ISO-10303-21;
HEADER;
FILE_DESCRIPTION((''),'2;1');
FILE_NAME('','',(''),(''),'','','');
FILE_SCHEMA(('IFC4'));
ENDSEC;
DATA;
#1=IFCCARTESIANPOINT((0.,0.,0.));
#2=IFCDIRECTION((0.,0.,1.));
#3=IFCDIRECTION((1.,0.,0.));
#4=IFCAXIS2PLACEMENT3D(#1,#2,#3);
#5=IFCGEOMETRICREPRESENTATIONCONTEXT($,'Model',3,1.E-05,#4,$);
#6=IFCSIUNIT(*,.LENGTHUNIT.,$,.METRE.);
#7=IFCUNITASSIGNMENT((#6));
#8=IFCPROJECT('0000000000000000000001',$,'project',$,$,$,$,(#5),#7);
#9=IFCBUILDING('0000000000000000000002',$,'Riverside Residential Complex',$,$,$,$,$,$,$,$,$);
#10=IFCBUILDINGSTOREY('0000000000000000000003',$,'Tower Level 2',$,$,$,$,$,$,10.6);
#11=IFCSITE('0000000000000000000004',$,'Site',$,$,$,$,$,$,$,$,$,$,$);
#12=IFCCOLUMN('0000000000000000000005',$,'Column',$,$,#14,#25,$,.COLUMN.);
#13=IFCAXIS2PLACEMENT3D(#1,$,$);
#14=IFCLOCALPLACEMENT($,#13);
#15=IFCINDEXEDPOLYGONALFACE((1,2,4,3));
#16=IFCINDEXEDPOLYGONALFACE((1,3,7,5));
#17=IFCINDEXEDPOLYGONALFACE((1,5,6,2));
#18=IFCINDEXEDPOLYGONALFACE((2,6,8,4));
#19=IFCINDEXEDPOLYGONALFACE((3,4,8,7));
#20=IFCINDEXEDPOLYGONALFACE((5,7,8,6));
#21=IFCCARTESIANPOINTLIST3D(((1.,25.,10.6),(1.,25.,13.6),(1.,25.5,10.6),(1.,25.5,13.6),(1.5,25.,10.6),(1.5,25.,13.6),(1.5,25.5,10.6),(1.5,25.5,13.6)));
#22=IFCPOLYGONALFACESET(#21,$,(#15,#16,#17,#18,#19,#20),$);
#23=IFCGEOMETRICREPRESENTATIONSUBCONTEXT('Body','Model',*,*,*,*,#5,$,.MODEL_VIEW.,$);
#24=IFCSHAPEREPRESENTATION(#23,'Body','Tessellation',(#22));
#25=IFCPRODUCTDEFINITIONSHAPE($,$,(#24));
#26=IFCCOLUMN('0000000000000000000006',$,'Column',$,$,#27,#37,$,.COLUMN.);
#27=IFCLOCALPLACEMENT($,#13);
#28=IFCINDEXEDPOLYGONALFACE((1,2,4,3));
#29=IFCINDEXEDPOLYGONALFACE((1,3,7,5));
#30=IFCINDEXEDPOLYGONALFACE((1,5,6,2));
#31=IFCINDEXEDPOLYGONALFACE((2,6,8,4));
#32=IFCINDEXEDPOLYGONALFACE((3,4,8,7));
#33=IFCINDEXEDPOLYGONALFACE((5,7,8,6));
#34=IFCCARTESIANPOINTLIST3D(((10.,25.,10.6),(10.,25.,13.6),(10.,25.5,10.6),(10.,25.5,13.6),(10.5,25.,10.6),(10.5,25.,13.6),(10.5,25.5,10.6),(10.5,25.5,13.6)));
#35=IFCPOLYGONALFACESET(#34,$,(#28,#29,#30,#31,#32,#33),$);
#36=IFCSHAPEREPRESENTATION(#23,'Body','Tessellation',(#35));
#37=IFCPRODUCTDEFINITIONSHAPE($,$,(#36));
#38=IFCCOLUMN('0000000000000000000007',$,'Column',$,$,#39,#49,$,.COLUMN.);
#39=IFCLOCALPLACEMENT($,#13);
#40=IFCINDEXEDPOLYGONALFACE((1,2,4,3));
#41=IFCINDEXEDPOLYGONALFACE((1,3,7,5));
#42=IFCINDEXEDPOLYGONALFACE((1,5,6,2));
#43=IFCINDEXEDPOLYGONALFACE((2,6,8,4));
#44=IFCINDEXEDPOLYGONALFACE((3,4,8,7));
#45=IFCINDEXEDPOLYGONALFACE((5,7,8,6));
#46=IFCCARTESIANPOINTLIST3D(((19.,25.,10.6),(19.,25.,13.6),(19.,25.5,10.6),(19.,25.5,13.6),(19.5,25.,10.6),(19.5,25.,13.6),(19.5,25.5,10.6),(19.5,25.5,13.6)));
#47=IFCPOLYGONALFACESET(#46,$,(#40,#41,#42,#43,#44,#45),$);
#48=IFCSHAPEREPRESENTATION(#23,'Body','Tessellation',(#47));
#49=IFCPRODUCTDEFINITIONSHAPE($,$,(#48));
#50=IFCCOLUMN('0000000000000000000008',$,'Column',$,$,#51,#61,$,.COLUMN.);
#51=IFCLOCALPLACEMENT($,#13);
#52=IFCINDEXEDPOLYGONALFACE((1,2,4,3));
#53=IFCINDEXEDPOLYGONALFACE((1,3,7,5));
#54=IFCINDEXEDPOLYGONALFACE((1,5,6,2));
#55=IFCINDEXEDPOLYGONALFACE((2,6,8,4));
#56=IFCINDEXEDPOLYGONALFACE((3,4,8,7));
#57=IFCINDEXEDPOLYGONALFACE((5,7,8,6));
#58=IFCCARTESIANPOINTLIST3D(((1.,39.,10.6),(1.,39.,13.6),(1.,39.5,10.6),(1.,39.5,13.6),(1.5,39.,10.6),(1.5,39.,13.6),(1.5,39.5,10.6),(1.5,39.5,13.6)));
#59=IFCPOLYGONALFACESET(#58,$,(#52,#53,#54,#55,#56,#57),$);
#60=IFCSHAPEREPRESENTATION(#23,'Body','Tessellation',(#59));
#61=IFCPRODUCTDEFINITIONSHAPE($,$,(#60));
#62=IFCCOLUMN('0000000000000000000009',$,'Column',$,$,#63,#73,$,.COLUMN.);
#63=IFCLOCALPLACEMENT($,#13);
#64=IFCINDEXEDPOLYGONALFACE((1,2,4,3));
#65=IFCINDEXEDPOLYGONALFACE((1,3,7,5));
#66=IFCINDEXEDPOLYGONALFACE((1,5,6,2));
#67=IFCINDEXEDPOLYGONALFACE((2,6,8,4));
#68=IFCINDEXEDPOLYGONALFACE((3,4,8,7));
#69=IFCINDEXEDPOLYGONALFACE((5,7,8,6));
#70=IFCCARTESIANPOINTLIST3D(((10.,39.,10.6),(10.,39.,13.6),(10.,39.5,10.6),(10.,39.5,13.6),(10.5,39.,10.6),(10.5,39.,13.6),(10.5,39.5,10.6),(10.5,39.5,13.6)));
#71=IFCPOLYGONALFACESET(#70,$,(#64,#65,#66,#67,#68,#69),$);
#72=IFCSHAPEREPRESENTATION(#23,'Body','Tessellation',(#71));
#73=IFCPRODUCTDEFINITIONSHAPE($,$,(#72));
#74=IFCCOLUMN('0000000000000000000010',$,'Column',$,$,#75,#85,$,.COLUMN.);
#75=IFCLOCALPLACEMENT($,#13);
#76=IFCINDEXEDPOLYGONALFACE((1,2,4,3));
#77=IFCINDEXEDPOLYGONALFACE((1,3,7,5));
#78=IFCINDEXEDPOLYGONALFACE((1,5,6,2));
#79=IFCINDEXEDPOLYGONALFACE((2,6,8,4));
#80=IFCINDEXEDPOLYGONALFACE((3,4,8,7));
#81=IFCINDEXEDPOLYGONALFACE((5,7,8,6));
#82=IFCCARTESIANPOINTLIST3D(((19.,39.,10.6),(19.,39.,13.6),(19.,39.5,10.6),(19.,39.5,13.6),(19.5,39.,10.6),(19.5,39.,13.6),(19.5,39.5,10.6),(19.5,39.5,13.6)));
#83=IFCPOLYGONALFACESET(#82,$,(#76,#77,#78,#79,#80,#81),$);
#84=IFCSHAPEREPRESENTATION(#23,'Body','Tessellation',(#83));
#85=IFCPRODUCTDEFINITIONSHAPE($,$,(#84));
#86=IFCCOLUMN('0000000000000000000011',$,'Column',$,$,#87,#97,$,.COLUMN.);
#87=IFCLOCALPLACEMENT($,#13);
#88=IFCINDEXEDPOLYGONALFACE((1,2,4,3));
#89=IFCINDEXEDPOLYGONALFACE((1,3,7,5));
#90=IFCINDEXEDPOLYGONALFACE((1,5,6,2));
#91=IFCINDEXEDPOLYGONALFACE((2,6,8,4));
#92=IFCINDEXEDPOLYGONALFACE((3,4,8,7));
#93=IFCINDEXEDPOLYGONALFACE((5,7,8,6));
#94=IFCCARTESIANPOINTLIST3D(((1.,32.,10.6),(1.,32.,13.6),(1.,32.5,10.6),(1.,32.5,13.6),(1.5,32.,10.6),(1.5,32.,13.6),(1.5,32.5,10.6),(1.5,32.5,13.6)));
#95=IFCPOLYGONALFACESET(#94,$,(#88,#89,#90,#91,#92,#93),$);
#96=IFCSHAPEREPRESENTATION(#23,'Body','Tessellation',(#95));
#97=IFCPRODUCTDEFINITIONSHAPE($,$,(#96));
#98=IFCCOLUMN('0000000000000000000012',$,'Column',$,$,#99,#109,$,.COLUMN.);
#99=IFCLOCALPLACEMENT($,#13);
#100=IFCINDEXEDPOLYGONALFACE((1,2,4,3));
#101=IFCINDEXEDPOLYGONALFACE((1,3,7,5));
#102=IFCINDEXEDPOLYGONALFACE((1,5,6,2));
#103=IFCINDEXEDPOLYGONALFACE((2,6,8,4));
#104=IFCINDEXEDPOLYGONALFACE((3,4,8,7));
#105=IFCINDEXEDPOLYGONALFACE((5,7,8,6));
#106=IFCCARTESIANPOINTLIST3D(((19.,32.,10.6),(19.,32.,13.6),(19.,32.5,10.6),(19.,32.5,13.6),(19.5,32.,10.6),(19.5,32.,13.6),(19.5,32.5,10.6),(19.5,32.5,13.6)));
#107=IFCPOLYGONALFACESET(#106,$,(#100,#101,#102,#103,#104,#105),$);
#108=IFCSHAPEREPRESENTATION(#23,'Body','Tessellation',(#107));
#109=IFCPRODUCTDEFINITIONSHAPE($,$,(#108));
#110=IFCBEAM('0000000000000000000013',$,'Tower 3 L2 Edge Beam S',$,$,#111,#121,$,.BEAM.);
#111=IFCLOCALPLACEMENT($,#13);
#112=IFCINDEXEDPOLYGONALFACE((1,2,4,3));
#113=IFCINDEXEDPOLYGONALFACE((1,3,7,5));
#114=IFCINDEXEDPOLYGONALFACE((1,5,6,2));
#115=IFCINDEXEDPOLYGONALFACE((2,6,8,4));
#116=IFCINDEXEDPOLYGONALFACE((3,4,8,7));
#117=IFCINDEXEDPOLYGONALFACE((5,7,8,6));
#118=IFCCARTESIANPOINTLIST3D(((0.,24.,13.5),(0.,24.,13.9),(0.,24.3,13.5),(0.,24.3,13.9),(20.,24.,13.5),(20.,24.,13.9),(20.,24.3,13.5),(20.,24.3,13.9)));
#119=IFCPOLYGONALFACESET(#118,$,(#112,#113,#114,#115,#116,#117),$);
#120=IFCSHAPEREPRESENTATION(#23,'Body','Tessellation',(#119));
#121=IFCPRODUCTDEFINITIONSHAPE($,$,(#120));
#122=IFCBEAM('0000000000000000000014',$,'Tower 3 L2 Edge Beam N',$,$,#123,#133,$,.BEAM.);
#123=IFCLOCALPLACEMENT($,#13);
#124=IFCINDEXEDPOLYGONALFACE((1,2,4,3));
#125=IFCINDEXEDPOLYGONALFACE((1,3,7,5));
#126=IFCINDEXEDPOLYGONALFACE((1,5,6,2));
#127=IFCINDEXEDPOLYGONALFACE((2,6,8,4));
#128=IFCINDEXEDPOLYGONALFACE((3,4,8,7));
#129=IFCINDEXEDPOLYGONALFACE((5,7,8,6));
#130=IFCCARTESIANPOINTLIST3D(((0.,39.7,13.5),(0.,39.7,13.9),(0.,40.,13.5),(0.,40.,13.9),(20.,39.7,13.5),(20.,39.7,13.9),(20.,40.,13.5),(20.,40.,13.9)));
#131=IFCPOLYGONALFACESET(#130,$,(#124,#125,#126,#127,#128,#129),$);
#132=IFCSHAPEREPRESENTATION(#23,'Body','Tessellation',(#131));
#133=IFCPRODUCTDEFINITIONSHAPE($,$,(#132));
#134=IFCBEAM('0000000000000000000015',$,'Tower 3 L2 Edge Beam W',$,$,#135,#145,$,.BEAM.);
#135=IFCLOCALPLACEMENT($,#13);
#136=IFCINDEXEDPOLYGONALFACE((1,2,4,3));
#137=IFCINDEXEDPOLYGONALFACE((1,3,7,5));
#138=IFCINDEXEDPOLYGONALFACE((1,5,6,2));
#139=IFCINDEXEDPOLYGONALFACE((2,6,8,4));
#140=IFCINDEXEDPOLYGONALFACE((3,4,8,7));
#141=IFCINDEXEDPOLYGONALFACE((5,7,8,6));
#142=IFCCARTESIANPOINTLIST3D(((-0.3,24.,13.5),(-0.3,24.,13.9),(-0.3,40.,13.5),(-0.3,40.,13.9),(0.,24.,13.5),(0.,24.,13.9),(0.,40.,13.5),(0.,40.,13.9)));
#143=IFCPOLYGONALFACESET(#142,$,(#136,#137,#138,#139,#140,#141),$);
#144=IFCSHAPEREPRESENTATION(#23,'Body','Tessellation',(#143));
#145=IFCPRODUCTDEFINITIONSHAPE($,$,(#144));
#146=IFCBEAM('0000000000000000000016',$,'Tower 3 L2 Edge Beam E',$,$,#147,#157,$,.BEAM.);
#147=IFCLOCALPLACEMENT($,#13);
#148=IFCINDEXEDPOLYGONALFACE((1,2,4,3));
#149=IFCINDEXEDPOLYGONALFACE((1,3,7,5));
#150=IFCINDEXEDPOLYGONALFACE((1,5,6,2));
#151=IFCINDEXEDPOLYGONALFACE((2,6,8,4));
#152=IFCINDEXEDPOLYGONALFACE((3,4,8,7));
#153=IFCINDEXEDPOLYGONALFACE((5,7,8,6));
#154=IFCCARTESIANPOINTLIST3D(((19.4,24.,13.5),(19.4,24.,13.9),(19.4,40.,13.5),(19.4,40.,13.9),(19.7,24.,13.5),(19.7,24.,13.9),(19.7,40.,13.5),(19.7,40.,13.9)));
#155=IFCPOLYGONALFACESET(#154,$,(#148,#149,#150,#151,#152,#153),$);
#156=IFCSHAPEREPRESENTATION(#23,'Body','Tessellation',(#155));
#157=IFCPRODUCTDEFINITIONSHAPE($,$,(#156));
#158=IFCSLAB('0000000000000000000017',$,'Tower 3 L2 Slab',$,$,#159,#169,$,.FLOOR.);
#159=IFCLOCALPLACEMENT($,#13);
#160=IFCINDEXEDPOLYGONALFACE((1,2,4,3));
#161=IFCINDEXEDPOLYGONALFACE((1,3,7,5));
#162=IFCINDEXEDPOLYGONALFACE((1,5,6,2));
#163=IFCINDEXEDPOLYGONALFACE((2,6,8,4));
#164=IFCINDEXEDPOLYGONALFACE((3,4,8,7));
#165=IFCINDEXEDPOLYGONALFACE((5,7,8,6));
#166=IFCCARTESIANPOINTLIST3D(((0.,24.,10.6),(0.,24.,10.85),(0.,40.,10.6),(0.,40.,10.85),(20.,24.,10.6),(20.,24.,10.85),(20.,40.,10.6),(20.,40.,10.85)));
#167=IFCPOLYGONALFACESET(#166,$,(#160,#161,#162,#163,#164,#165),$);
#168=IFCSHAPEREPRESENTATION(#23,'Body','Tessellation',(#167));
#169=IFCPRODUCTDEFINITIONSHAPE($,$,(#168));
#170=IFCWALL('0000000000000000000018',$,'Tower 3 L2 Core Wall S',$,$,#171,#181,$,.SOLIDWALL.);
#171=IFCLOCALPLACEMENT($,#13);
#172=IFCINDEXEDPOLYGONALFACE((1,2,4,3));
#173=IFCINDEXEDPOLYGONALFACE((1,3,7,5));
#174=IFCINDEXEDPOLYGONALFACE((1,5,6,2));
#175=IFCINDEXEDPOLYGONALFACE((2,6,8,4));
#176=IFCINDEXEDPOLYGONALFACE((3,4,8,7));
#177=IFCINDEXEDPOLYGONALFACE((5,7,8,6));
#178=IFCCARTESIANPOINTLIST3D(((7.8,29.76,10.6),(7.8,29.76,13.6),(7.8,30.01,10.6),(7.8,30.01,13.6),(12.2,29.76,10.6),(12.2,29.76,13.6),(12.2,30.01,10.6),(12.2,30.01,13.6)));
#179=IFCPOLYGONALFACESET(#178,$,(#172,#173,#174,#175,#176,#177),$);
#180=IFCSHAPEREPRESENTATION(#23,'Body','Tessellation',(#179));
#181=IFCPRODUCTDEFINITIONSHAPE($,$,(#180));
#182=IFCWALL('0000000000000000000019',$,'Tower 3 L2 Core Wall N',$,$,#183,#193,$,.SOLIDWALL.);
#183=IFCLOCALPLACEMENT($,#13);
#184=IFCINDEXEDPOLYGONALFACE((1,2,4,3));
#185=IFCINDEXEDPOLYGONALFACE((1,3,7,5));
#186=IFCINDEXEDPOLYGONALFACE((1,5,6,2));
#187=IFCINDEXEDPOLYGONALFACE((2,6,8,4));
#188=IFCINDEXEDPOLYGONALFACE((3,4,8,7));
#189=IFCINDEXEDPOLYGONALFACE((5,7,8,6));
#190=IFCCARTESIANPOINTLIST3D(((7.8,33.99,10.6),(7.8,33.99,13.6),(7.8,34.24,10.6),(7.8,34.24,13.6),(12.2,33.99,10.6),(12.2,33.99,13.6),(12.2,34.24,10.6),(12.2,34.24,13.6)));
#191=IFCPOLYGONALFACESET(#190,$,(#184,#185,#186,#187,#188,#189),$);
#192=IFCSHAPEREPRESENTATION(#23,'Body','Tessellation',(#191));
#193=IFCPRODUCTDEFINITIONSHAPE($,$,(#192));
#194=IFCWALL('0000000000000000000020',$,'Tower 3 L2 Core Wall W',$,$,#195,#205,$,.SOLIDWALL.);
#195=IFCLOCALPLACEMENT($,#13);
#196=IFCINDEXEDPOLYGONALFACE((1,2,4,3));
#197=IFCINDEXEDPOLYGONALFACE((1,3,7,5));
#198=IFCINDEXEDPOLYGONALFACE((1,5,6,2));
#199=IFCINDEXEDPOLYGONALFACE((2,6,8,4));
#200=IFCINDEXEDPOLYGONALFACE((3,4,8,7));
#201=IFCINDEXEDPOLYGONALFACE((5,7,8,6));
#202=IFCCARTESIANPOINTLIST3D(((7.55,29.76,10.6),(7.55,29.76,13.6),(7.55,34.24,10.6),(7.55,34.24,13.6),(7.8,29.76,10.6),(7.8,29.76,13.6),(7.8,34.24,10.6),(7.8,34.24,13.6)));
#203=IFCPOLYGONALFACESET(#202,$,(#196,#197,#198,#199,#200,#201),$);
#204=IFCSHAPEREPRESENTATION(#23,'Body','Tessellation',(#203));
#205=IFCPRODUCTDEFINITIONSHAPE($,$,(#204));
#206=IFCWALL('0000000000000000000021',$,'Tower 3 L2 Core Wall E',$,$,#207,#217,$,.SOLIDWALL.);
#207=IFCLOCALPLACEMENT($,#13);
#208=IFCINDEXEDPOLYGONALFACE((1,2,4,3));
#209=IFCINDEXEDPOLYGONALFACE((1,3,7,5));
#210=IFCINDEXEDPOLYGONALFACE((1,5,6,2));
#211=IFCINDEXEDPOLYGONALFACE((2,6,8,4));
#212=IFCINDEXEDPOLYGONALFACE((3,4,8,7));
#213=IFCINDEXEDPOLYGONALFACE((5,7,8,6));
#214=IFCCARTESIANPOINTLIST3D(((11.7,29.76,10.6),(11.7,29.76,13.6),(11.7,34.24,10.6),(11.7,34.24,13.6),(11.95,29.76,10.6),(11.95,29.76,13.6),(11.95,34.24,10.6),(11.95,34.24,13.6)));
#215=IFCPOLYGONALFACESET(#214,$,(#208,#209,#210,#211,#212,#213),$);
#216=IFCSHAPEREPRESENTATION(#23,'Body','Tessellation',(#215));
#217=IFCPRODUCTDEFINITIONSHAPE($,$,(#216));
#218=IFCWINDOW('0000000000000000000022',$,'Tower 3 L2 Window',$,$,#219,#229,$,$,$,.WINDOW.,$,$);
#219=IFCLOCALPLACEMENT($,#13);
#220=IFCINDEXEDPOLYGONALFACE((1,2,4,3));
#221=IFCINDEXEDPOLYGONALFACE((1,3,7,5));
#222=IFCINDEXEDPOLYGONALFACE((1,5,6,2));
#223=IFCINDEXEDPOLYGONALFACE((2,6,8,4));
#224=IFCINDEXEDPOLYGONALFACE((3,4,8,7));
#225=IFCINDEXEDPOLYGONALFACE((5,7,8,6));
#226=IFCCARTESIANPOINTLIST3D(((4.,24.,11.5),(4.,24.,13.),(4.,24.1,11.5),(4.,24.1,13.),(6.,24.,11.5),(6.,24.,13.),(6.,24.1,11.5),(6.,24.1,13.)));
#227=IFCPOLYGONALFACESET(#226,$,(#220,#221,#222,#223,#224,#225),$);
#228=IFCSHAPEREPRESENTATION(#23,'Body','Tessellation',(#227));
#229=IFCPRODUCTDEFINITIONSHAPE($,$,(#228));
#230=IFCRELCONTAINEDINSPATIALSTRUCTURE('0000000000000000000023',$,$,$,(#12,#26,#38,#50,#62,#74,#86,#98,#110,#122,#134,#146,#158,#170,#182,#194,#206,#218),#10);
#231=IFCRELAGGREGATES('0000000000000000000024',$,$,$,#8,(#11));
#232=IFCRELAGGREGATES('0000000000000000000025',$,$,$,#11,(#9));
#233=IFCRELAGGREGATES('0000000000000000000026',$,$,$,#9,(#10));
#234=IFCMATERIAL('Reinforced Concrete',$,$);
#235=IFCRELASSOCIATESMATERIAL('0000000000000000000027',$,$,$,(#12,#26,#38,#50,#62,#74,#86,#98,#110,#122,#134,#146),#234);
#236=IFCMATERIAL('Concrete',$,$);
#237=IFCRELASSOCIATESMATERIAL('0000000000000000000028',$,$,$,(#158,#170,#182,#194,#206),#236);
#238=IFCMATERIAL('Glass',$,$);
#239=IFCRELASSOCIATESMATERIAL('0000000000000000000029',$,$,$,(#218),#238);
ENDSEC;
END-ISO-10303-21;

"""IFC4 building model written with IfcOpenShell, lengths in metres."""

from ifc_helpers import new_model, si_unit, frame, origin_with_axes, place, context, subcontext, project, spatial, line, indexed_curve, outline, extrude, material, element, save


model = new_model("IFC4")

# Units and contexts
model_context = context("Model", 3, precision=1e-05, world=origin_with_axes())
body_context = subcontext(model_context, "Body", "Model", "MODEL_VIEW")
ifc_project = project(units=[si_unit("LENGTHUNIT", "METRE")], contexts=[model_context])

# Site, building, storey
site = spatial("IfcSite", under=ifc_project, Name="Site")
building = spatial("IfcBuilding", under=site, Name="Riverside Residential Complex")
storey = spatial("IfcBuildingStorey", under=building, Name="Tower Level 2", Elevation=10.6)

# Columns
ifc_material_1 = material(Name="Reinforced Concrete")
for number, where, z_axis, x_axis, name in (
    (1, (1.0, 25.0, 10.6), (0.0, 0.0, 1.0), (1.0, 0.0, 0.0), "Column"),
    (2, (10.0, 25.0, 10.6), (0.0, 0.0, 1.0), (1.0, 0.0, 0.0), "Column"),
    (3, (19.0, 25.0, 10.6), (0.0, 0.0, 1.0), (1.0, 0.0, 0.0), "Column"),
    (4, (1.0, 39.0, 10.6), (0.0, 0.0, 1.0), (1.0, 0.0, 0.0), "Column"),
    (5, (10.0, 39.0, 10.6), (0.0, 0.0, 1.0), (1.0, 0.0, 0.0), "Column"),
    (6, (19.0, 39.0, 10.6), (0.0, 0.0, 1.0), (1.0, 0.0, 0.0), "Column"),
    (7, (1.0, 32.0, 10.6), (0.0, 0.0, 1.0), (1.0, 0.0, 0.0), "Column"),
    (8, (19.0, 32.0, 10.6), (0.0, 0.0, 1.0), (1.0, 0.0, 0.0), "Column"),
):
    element("IfcColumn", number, at=place(None, frame(where, z_axis=z_axis, x_axis=x_axis)), inside=storey, material=ifc_material_1, Name=name, PredefinedType="COLUMN", context=body_context, shape_type="SweptSolid", body=[
        extrude(outline(indexed_curve([(0.0, 0.0), (0.5, 0.0), (0.5, 0.5), (0.0, 0.5)], segments=[line(1, 2, 3, 4, 1)])), origin_with_axes(), (0.0, 0.0, 1.0), 3.0),
    ])

# Beams
for number, where, z_axis, x_axis, name in (
    (9, (0.0, 24.0, 13.5), (0.0, 0.0, 1.0), (1.0, 0.0, 0.0), "Tower 3 L2 Edge Beam S"),
    (10, (0.0, 39.7, 13.5), (0.0, 0.0, 1.0), (1.0, 0.0, 0.0), "Tower 3 L2 Edge Beam N"),
):
    element("IfcBeam", number, at=place(None, frame(where, z_axis=z_axis, x_axis=x_axis)), inside=storey, material=ifc_material_1, Name=name, PredefinedType="BEAM", context=body_context, shape_type="SweptSolid", body=[
        extrude(outline(indexed_curve([(0.0, 0.0), (20.0, 0.0), (20.0, 0.3), (0.0, 0.3)], segments=[line(1, 2, 3, 4, 1)])), origin_with_axes(), (0.0, 0.0, 1.0), 0.4),
    ])
for number, where, z_axis, x_axis, name in (
    (11, (0.0, 24.0, 13.5), (0.0, 0.0, 1.0), (0.0, 1.0, 0.0), "Tower 3 L2 Edge Beam W"),
    (12, (19.7, 24.0, 13.5), (0.0, 0.0, 1.0), (0.0, 1.0, 0.0), "Tower 3 L2 Edge Beam E"),
):
    element("IfcBeam", number, at=place(None, frame(where, z_axis=z_axis, x_axis=x_axis)), inside=storey, material=ifc_material_1, Name=name, PredefinedType="BEAM", context=body_context, shape_type="SweptSolid", body=[
        extrude(outline(indexed_curve([(0.0, 0.0), (16.0, 0.0), (16.0, 0.3), (0.0, 0.3)], segments=[line(1, 2, 3, 4, 1)])), origin_with_axes(), (0.0, 0.0, 1.0), 0.4),
    ])

# Slab
ifc_material_2 = material(Name="Concrete")
slab_placement = place(None, frame((0.0, 24.0, 10.6), z_axis=(0.0, 0.0, 1.0), x_axis=(1.0, 0.0, 0.0)))
element("IfcSlab", 13, at=slab_placement, inside=storey, material=ifc_material_2, Name="Tower 3 L2 Slab", PredefinedType="FLOOR", context=body_context, shape_type="SweptSolid", body=[
    extrude(outline(indexed_curve([(0.0, 0.0), (20.0, 0.0), (20.0, 16.0), (0.0, 16.0)], segments=[line(1, 2, 3, 4, 1)])), origin_with_axes(), (0.0, 0.0, 1.0), 0.25),
])

# Walls
for number, where, z_axis, x_axis, name in (
    (14, (7.8, 29.76, 10.6), (0.0, 0.0, 1.0), (1.0, 0.0, 0.0), "Tower 3 L2 Core Wall S"),
    (15, (7.8, 33.99, 10.6), (0.0, 0.0, 1.0), (1.0, 0.0, 0.0), "Tower 3 L2 Core Wall N"),
):
    element("IfcWall", number, at=place(None, frame(where, z_axis=z_axis, x_axis=x_axis)), inside=storey, material=ifc_material_2, Name=name, PredefinedType="SOLIDWALL", context=body_context, shape_type="SweptSolid", body=[
        extrude(outline(indexed_curve([(0.0, 0.0), (4.4, 0.0), (4.4, 0.25), (0.0, 0.25)], segments=[line(1, 2, 3, 4, 1)])), origin_with_axes(), (0.0, 0.0, 1.0), 3.0),
    ])
for number, where, z_axis, x_axis, name in (
    (16, (7.8, 29.76, 10.6), (0.0, 0.0, 1.0), (0.0, 1.0, 0.0), "Tower 3 L2 Core Wall W"),
    (17, (11.95, 29.76, 10.6), (0.0, 0.0, 1.0), (0.0, 1.0, 0.0), "Tower 3 L2 Core Wall E"),
):
    element("IfcWall", number, at=place(None, frame(where, z_axis=z_axis, x_axis=x_axis)), inside=storey, material=ifc_material_2, Name=name, PredefinedType="SOLIDWALL", context=body_context, shape_type="SweptSolid", body=[
        extrude(outline(indexed_curve([(0.0, 0.0), (4.48, 0.0), (4.48, 0.25), (0.0, 0.25)], segments=[line(1, 2, 3, 4, 1)])), origin_with_axes(), (0.0, 0.0, 1.0), 3.0),
    ])

# Window
ifc_material_3 = material(Name="Glass")
for number, where, z_axis, x_axis, name in (
    (18, (4.0, 24.0, 11.5), (0.0, 0.0, 1.0), (1.0, 0.0, 0.0), "Tower 3 L2 Window"),
):
    element("IfcWindow", number, at=place(None, frame(where, z_axis=z_axis, x_axis=x_axis)), inside=storey, material=ifc_material_3, Name=name, PredefinedType="WINDOW", context=body_context, shape_type="SweptSolid", body=[
        extrude(outline(indexed_curve([(0.0, 0.0), (2.0, 0.0), (2.0, 0.1), (0.0, 0.1)], segments=[line(1, 2, 3, 4, 1)])), origin_with_axes(), (0.0, 0.0, 1.0), 1.5),
    ])

save(model, "model.ifc")
